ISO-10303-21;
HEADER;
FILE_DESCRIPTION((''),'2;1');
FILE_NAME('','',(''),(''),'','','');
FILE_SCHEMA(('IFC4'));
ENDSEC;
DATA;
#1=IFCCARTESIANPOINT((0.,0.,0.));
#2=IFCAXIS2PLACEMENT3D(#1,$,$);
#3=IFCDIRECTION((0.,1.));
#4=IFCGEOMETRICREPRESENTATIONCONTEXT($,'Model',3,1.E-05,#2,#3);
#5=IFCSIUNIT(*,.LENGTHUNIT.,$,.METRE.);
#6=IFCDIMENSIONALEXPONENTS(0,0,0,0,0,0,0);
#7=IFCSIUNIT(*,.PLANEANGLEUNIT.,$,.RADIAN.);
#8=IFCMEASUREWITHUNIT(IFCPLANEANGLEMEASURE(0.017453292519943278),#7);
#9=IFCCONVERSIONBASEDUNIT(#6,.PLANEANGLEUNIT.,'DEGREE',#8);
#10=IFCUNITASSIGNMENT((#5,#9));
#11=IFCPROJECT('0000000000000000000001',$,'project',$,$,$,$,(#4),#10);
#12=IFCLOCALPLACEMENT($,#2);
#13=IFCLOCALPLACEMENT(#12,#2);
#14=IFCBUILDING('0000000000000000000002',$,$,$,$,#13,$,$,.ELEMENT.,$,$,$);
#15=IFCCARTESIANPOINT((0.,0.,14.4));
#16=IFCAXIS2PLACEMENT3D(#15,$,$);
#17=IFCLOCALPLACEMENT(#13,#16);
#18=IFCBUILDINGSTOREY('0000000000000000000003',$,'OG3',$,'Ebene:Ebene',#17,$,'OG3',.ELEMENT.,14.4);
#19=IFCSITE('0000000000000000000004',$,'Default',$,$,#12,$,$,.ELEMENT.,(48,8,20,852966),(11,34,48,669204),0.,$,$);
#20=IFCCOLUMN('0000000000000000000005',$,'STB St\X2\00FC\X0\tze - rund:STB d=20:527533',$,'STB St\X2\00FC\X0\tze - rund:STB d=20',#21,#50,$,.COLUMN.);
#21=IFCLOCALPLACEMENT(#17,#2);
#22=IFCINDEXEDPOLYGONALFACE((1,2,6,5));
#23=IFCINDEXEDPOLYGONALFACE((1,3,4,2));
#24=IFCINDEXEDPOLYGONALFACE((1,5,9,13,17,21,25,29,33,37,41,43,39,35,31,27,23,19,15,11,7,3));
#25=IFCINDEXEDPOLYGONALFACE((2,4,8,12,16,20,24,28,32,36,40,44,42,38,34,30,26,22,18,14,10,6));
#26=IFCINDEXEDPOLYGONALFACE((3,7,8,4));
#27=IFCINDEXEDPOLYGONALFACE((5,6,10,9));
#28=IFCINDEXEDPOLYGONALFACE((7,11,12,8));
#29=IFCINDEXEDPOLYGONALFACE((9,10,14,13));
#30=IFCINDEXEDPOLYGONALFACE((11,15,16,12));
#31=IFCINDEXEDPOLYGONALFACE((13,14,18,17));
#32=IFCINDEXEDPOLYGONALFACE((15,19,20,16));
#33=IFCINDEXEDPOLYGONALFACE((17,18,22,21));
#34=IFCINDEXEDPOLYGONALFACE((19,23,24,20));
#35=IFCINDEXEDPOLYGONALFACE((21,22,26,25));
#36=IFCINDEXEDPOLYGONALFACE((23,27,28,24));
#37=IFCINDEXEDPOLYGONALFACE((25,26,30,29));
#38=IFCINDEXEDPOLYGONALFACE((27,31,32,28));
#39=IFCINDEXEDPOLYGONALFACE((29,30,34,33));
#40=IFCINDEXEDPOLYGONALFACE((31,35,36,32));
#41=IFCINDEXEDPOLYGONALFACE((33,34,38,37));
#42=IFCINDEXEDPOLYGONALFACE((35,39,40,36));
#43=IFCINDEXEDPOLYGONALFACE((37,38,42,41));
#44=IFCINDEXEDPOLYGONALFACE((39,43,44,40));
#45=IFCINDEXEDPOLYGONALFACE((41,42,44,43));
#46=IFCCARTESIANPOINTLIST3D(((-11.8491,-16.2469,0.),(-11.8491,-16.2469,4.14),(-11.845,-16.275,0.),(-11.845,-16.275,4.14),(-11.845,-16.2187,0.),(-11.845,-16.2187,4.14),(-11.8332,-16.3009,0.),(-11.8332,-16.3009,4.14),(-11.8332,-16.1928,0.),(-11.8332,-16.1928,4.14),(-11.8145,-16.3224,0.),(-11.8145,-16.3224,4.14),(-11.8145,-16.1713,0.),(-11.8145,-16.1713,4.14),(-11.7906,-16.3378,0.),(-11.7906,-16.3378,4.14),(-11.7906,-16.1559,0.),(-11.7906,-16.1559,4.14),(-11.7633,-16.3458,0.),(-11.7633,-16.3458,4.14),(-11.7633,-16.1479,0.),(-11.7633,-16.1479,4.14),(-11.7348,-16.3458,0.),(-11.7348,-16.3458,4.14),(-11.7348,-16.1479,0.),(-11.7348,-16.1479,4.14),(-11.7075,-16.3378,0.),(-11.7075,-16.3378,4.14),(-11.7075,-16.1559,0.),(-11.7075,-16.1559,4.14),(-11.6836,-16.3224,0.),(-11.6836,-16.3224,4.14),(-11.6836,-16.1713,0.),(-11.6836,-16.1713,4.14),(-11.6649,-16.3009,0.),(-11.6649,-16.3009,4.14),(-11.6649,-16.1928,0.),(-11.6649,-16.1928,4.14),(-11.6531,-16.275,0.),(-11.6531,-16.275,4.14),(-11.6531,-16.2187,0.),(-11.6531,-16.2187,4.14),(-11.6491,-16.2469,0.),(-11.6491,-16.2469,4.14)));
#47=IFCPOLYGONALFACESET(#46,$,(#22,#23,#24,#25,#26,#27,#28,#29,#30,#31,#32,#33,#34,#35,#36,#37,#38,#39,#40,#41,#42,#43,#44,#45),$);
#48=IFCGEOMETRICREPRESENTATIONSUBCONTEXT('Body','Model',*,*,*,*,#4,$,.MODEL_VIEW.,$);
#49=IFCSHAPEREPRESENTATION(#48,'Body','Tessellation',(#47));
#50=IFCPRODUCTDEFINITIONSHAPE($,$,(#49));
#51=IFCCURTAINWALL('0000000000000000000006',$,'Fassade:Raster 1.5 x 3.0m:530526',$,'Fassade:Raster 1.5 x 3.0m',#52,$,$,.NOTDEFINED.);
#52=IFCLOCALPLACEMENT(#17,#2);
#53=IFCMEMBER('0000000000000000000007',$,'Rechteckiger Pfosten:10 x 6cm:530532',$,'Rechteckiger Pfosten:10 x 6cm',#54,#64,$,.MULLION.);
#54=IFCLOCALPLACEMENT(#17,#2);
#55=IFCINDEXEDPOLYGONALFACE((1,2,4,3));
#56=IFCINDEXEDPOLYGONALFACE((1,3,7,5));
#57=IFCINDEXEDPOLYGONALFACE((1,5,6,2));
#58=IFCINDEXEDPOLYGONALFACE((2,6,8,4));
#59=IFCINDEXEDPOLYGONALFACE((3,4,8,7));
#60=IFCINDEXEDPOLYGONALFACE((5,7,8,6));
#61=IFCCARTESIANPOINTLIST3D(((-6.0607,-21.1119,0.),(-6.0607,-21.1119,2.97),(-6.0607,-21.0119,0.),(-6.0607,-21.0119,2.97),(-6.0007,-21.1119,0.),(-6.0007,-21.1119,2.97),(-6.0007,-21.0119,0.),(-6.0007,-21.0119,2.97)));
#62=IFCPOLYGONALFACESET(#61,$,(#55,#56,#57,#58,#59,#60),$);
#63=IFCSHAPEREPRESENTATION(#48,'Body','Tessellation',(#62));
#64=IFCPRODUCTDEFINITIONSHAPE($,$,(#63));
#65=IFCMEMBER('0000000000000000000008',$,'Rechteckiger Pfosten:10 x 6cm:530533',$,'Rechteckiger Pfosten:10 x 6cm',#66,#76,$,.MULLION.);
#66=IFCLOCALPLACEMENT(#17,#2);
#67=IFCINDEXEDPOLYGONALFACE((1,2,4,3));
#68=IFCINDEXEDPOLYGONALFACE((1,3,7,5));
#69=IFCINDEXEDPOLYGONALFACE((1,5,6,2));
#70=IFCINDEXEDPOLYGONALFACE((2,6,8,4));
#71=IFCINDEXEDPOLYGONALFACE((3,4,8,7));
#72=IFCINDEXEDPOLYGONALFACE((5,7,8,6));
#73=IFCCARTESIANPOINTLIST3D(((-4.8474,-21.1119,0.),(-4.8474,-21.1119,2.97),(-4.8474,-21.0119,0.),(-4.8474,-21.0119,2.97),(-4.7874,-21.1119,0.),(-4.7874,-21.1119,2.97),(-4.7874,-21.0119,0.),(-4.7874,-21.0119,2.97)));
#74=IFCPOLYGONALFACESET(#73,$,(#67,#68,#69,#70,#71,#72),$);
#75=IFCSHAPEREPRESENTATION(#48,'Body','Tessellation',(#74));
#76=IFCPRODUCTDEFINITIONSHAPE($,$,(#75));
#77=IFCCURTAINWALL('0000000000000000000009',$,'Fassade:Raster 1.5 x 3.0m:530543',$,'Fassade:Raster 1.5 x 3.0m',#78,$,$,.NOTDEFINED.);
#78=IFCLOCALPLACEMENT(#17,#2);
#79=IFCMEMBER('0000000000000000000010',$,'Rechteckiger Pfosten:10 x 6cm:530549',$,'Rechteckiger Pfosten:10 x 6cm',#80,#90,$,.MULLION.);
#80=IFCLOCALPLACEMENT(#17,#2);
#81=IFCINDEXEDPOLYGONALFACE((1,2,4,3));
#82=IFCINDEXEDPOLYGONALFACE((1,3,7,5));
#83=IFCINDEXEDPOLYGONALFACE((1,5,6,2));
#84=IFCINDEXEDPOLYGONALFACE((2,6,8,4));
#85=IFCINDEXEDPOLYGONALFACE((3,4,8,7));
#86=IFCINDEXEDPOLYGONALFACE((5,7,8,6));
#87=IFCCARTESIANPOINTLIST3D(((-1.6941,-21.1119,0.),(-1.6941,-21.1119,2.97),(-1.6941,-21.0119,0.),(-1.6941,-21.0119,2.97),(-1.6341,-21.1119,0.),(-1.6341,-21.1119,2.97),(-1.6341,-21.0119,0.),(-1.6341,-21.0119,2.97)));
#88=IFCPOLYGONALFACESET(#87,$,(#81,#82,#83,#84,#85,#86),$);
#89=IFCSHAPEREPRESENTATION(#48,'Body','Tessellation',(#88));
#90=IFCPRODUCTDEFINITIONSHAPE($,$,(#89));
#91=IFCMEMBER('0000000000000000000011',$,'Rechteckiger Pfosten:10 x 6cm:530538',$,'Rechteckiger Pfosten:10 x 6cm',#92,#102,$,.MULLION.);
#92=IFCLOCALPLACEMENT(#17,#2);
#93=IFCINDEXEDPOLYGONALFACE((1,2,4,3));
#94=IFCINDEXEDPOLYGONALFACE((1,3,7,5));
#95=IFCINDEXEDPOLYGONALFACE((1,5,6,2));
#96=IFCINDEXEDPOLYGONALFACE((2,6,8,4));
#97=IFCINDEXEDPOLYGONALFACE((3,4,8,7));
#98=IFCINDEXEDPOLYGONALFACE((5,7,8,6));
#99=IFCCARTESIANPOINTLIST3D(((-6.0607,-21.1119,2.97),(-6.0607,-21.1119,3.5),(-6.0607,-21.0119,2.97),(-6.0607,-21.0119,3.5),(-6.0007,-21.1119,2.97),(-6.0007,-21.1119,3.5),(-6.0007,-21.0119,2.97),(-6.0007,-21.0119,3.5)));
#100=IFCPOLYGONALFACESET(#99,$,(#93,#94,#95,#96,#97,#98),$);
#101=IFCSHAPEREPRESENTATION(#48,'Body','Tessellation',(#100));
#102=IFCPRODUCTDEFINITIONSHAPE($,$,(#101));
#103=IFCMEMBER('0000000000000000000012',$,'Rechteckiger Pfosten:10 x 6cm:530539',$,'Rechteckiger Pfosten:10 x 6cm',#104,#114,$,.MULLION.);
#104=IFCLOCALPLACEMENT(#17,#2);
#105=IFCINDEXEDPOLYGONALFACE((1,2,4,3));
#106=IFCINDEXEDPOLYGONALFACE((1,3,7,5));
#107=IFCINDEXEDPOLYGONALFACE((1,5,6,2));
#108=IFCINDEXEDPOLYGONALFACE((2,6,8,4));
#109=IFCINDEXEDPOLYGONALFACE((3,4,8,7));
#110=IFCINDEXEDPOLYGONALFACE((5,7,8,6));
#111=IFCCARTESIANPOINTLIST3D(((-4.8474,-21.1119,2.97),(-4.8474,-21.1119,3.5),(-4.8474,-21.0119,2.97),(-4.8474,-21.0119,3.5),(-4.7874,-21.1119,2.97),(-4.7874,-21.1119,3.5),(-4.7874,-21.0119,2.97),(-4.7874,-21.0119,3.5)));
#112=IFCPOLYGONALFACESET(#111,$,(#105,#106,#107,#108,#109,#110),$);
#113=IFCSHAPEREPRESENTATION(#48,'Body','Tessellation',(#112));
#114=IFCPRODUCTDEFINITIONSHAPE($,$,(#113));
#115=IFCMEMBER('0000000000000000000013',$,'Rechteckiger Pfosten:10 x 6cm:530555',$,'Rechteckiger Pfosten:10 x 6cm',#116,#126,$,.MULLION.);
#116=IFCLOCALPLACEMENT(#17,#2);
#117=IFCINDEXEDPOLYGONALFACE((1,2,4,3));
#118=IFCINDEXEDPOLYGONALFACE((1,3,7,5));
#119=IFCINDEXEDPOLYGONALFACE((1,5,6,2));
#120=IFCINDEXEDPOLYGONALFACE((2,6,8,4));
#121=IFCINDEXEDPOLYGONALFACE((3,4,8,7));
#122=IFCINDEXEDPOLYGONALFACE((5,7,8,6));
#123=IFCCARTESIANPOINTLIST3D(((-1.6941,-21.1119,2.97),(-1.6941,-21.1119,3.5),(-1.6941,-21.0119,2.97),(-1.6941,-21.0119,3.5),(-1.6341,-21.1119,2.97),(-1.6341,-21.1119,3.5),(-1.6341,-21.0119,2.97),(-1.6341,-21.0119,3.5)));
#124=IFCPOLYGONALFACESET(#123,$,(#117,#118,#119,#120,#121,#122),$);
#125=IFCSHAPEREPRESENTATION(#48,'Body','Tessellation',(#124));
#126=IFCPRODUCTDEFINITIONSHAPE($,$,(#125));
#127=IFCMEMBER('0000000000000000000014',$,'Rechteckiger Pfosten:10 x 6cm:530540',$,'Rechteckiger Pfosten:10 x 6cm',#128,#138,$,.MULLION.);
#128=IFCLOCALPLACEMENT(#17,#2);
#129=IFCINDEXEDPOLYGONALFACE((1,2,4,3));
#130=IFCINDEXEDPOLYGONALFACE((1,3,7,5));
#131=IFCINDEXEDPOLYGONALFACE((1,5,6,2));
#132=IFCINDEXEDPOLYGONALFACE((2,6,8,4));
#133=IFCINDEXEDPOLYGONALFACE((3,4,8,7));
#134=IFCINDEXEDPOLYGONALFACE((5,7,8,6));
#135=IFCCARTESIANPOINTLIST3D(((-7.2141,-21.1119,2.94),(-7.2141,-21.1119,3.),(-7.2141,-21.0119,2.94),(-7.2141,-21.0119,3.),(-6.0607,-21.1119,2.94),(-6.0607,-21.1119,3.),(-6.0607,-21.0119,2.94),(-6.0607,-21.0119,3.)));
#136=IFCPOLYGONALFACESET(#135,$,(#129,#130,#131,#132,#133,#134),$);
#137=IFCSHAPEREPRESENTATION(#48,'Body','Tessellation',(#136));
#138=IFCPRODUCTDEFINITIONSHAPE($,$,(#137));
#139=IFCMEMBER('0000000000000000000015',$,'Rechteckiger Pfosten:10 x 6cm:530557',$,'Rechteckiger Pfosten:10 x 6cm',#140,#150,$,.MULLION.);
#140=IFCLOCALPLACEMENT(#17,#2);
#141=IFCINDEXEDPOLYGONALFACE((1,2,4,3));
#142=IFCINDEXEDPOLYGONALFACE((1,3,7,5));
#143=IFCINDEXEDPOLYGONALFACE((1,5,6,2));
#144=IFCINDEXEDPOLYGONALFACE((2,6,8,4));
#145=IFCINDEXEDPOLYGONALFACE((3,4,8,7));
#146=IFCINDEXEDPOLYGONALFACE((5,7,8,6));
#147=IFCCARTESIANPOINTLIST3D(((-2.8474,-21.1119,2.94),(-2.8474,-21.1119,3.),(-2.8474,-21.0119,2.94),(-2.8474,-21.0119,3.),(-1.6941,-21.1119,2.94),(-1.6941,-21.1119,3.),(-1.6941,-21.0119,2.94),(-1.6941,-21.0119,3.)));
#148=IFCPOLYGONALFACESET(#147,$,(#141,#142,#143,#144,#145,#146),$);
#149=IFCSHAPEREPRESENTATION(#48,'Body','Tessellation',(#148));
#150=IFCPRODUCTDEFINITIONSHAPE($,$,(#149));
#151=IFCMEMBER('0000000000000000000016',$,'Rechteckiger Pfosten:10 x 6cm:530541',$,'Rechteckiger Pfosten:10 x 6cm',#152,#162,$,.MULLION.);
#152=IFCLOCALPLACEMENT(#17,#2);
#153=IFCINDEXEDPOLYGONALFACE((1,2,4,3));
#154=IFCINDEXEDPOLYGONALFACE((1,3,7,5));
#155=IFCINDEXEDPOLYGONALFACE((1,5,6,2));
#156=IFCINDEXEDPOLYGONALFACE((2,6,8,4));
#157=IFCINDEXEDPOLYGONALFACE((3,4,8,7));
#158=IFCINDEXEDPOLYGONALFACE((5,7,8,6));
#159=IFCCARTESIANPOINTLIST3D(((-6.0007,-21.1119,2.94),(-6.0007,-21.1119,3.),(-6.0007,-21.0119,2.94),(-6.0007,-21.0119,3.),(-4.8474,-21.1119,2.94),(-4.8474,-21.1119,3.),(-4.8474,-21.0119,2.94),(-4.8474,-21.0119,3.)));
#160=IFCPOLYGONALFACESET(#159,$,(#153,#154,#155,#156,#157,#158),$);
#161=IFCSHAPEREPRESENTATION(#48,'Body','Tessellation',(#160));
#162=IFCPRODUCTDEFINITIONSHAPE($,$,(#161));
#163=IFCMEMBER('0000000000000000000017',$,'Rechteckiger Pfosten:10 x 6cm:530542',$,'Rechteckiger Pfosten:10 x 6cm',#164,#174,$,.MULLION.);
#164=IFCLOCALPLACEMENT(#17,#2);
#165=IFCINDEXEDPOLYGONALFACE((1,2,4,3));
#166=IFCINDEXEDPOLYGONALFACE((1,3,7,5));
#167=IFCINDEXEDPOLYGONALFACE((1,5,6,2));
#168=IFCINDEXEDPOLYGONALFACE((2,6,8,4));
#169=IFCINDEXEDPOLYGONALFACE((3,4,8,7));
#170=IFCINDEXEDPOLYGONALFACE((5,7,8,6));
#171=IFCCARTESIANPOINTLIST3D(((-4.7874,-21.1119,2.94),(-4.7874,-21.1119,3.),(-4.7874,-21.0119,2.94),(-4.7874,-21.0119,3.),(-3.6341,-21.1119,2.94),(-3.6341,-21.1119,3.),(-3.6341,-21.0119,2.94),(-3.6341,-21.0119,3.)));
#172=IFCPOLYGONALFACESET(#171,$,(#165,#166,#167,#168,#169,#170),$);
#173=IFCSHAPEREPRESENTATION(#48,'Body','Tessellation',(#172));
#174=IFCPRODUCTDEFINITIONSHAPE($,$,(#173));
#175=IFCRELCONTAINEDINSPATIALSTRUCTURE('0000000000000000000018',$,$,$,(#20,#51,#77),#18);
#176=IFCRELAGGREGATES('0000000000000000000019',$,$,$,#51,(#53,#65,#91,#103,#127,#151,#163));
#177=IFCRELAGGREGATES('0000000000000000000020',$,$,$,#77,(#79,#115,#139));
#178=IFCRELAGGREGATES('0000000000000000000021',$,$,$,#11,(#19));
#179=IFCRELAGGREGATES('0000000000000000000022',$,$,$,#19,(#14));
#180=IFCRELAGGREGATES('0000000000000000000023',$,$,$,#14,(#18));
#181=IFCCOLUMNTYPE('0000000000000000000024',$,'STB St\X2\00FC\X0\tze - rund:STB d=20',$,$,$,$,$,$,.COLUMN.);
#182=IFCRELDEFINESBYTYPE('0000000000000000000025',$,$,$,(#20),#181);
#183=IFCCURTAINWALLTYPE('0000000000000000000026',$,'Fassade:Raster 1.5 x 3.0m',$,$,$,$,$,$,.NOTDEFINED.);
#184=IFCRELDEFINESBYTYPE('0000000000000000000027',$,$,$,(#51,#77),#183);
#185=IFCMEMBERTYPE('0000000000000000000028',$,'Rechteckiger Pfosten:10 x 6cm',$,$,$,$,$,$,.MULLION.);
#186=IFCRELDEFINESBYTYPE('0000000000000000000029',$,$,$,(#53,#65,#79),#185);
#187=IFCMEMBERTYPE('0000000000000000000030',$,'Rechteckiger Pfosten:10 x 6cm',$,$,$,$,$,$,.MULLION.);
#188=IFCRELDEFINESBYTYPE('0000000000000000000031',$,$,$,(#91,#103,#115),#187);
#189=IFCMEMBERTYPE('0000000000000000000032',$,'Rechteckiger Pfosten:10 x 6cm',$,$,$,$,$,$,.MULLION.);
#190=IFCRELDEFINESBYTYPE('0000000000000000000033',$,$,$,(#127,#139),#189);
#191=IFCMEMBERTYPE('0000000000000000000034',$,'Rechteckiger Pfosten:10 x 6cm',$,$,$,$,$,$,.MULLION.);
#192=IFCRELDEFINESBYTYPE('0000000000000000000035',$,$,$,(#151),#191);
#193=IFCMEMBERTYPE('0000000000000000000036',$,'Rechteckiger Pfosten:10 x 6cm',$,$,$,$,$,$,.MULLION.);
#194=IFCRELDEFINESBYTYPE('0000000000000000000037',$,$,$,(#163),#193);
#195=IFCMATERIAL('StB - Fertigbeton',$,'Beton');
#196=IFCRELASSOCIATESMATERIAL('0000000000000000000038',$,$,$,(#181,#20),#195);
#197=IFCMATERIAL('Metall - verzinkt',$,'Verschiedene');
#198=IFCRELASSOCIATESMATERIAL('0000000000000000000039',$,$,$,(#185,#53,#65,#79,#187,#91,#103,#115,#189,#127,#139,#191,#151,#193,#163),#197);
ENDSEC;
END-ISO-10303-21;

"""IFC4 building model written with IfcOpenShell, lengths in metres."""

from ifc_helpers import new_model, entity, si_unit, converted_unit, direction, frame, origin, place, context, subcontext, project, spatial, arc, indexed_curve, outline, extrude, source, transform, mapped, material, type_object, type_shapes, element, aggregate, save


model = new_model("IFC4")

# Units and contexts
model_context = context("Model", 3, precision=1e-05, world=origin(), true_north=direction((0.0, 1.0)))
body_context = subcontext(model_context, "Body", "Model", "MODEL_VIEW")
ifc_project = project(units=[si_unit("LENGTHUNIT", "METRE"), converted_unit("PLANEANGLEUNIT", "DEGREE", entity("IfcPlaneAngleMeasure", 0.017453292519943278), si_unit("PLANEANGLEUNIT", "RADIAN"), dimensions=[0, 0, 0, 0, 0, 0, 0])], contexts=[model_context])

# Site, building, storey
site_placement = place(None, origin())
site = spatial("IfcSite", under=ifc_project, at=site_placement, Name="Default", CompositionType="ELEMENT", RefLatitude=(48, 8, 20, 852966), RefLongitude=(11, 34, 48, 669204), RefElevation=0.0)
building_placement = place(site_placement, origin())
building = spatial("IfcBuilding", under=site, at=building_placement, CompositionType="ELEMENT")
storey_placement = place(building_placement, frame((0.0, 0.0, 14.4)))
storey = spatial("IfcBuildingStorey", under=building, at=storey_placement, Name="OG3", ObjectType="Ebene:Ebene", LongName="OG3", CompositionType="ELEMENT", Elevation=14.4)

# Column
ifc_material_1 = material(Name="StB - Fertigbeton", Category="Beton")
column_type = type_object("IfcColumnType", Name="STB Stütze - rund:STB d=20", PredefinedType="COLUMN", material=ifc_material_1)
shared_shape_1 = source(origin(), body_context, "Body", "SweptSolid", [
    extrude(outline(indexed_curve([(-0.1, 0.0), (0.0, -0.1), (0.1, 0.0), (0.0, 0.1)], segments=[arc(1, 2, 3), arc(3, 4, 1)], self_intersect=False)), frame((0.0, 0.0, 14.4)), (0.0, 0.0, 1.0), 4.14),
])
type_shapes(column_type, [shared_shape_1])
column_placement = place(storey_placement, frame((-11.7491, -16.2469, -14.4), z_axis=(0.0, 0.0, 1.0), x_axis=(-1.0, 0.0, 0.0)))
element("IfcColumn", 1, at=column_placement, inside=storey, type_object=column_type, material=ifc_material_1, Name="STB Stütze - rund:STB d=20:527533", ObjectType="STB Stütze - rund:STB d=20", PredefinedType="COLUMN", context=body_context, shape_type="MappedRepresentation", body=[
    mapped(shared_shape_1, transform((0.0, 0.0, 0.0), scale=1.0)),
])

# Curtain wall, members
curtain_wall_type = type_object("IfcCurtainWallType", Name="Fassade:Raster 1.5 x 3.0m", PredefinedType="NOTDEFINED")
curtain_wall_1_placement = place(storey_placement, frame((0.0, 0.0, -14.4)))
curtain_wall_1 = element("IfcCurtainWall", 2, at=curtain_wall_1_placement, inside=storey, type_object=curtain_wall_type, Name="Fassade:Raster 1.5 x 3.0m:530526", ObjectType="Fassade:Raster 1.5 x 3.0m", PredefinedType="NOTDEFINED")
ifc_material_2 = material(Name="Metall - verzinkt", Category="Verschiedene")
member_type_1 = type_object("IfcMemberType", Name="Rechteckiger Pfosten:10 x 6cm", PredefinedType="MULLION", material=ifc_material_2)
shared_shape_2 = source(origin(), body_context, "Body", "SweptSolid", [
    extrude(outline(indexed_curve([(-0.03, -0.05), (0.03, -0.05), (0.03, 0.05), (-0.03, 0.05), (-0.03, -0.05)], self_intersect=False)), frame((0.0, 0.0, -2.97), z_axis=(0.0, 0.0, 1.0), x_axis=(-1.0, 0.0, 0.0)), (0.0, 0.0, 1.0), 2.97),
])
type_shapes(member_type_1, [shared_shape_2])
member_1_placement = place(curtain_wall_1_placement, frame((-6.0307, -21.0619, 14.4), z_axis=(0.0, 0.0, -1.0), x_axis=(1.0, 0.0, 0.0)))
member_1 = element("IfcMember", 3, at=member_1_placement, type_object=member_type_1, material=ifc_material_2, Name="Rechteckiger Pfosten:10 x 6cm:530532", ObjectType="Rechteckiger Pfosten:10 x 6cm", PredefinedType="MULLION", context=body_context, shape_type="MappedRepresentation", body=[
    mapped(shared_shape_2, transform((0.0, 0.0, 0.0), scale=1.0)),
])
member_2_placement = place(curtain_wall_1_placement, frame((-4.8174, -21.0619, 14.4), z_axis=(0.0, 0.0, -1.0), x_axis=(1.0, 0.0, 0.0)))
member_2 = element("IfcMember", 4, at=member_2_placement, type_object=member_type_1, material=ifc_material_2, Name="Rechteckiger Pfosten:10 x 6cm:530533", ObjectType="Rechteckiger Pfosten:10 x 6cm", PredefinedType="MULLION", context=body_context, shape_type="MappedRepresentation", body=[
    mapped(shared_shape_2, transform((0.0, 0.0, 0.0), scale=1.0)),
])

# Curtain wall, member
curtain_wall_2_placement = place(storey_placement, frame((0.0, 0.0, -14.4)))
curtain_wall_2 = element("IfcCurtainWall", 5, at=curtain_wall_2_placement, inside=storey, type_object=curtain_wall_type, Name="Fassade:Raster 1.5 x 3.0m:530543", ObjectType="Fassade:Raster 1.5 x 3.0m", PredefinedType="NOTDEFINED")
member_3_placement = place(curtain_wall_2_placement, frame((-1.6641, -21.0619, 14.4), z_axis=(0.0, 0.0, -1.0), x_axis=(1.0, 0.0, 0.0)))
member_3 = element("IfcMember", 6, at=member_3_placement, type_object=member_type_1, material=ifc_material_2, Name="Rechteckiger Pfosten:10 x 6cm:530549", ObjectType="Rechteckiger Pfosten:10 x 6cm", PredefinedType="MULLION", context=body_context, shape_type="MappedRepresentation", body=[
    mapped(shared_shape_2, transform((0.0, 0.0, 0.0), scale=1.0)),
])

# Members
member_type_2 = type_object("IfcMemberType", Name="Rechteckiger Pfosten:10 x 6cm", PredefinedType="MULLION", material=ifc_material_2)
shared_shape_3 = source(origin(), body_context, "Body", "SweptSolid", [
    extrude(outline(indexed_curve([(-0.03, -0.05), (0.03, -0.05), (0.03, 0.05), (-0.03, 0.05), (-0.03, -0.05)], self_intersect=False)), frame((0.0, 0.0, -0.53), z_axis=(0.0, 0.0, 1.0), x_axis=(-1.0, 0.0, 0.0)), (0.0, 0.0, 1.0), 0.53),
])
type_shapes(member_type_2, [shared_shape_3])
member_4_placement = place(curtain_wall_1_placement, frame((-6.0307, -21.0619, 17.37), z_axis=(0.0, 0.0, -1.0), x_axis=(1.0, 0.0, 0.0)))
member_4 = element("IfcMember", 7, at=member_4_placement, type_object=member_type_2, material=ifc_material_2, Name="Rechteckiger Pfosten:10 x 6cm:530538", ObjectType="Rechteckiger Pfosten:10 x 6cm", PredefinedType="MULLION", context=body_context, shape_type="MappedRepresentation", body=[
    mapped(shared_shape_3, transform((0.0, 0.0, 0.0), scale=1.0)),
])
member_5_placement = place(curtain_wall_1_placement, frame((-4.8174, -21.0619, 17.37), z_axis=(0.0, 0.0, -1.0), x_axis=(1.0, 0.0, 0.0)))
member_5 = element("IfcMember", 8, at=member_5_placement, type_object=member_type_2, material=ifc_material_2, Name="Rechteckiger Pfosten:10 x 6cm:530539", ObjectType="Rechteckiger Pfosten:10 x 6cm", PredefinedType="MULLION", context=body_context, shape_type="MappedRepresentation", body=[
    mapped(shared_shape_3, transform((0.0, 0.0, 0.0), scale=1.0)),
])
member_6_placement = place(curtain_wall_2_placement, frame((-1.6641, -21.0619, 17.37), z_axis=(0.0, 0.0, -1.0), x_axis=(1.0, 0.0, 0.0)))
member_6 = element("IfcMember", 9, at=member_6_placement, type_object=member_type_2, material=ifc_material_2, Name="Rechteckiger Pfosten:10 x 6cm:530555", ObjectType="Rechteckiger Pfosten:10 x 6cm", PredefinedType="MULLION", context=body_context, shape_type="MappedRepresentation", body=[
    mapped(shared_shape_3, transform((0.0, 0.0, 0.0), scale=1.0)),
])
member_type_3 = type_object("IfcMemberType", Name="Rechteckiger Pfosten:10 x 6cm", PredefinedType="MULLION", material=ifc_material_2)
shared_shape_4 = source(origin(), body_context, "Body", "SweptSolid", [
    extrude(outline(indexed_curve([(-0.03, -0.05), (0.03, -0.05), (0.03, 0.05), (-0.03, 0.05), (-0.03, -0.05)], self_intersect=False)), frame((0.0, 0.0, -1.1533), z_axis=(0.0, 0.0, 1.0), x_axis=(-1.0, 0.0, 0.0)), (0.0, 0.0, 1.0), 1.1533),
])
type_shapes(member_type_3, [shared_shape_4])
member_7_placement = place(curtain_wall_1_placement, frame((-6.0607, -21.0619, 17.37), z_axis=(1.0, 0.0, 0.0), x_axis=(0.0, 0.0, 1.0)))
member_7 = element("IfcMember", 10, at=member_7_placement, type_object=member_type_3, material=ifc_material_2, Name="Rechteckiger Pfosten:10 x 6cm:530540", ObjectType="Rechteckiger Pfosten:10 x 6cm", PredefinedType="MULLION", context=body_context, shape_type="MappedRepresentation", body=[
    mapped(shared_shape_4, transform((0.0, 0.0, 0.0), scale=1.0)),
])
member_8_placement = place(curtain_wall_2_placement, frame((-1.6941, -21.0619, 17.37), z_axis=(1.0, 0.0, 0.0), x_axis=(0.0, 0.0, 1.0)))
member_8 = element("IfcMember", 11, at=member_8_placement, type_object=member_type_3, material=ifc_material_2, Name="Rechteckiger Pfosten:10 x 6cm:530557", ObjectType="Rechteckiger Pfosten:10 x 6cm", PredefinedType="MULLION", context=body_context, shape_type="MappedRepresentation", body=[
    mapped(shared_shape_4, transform((0.0, 0.0, 0.0), scale=1.0)),
])
member_type_4 = type_object("IfcMemberType", Name="Rechteckiger Pfosten:10 x 6cm", PredefinedType="MULLION", material=ifc_material_2)
shared_shape_5 = source(origin(), body_context, "Body", "SweptSolid", [
    extrude(outline(indexed_curve([(-0.03, -0.05), (0.03, -0.05), (0.03, 0.05), (-0.03, 0.05), (-0.03, -0.05)], self_intersect=False)), frame((0.0, 0.0, -1.1533), z_axis=(0.0, 0.0, 1.0), x_axis=(-1.0, 0.0, 0.0)), (0.0, 0.0, 1.0), 1.1533),
])
type_shapes(member_type_4, [shared_shape_5])
member_9_placement = place(curtain_wall_1_placement, frame((-4.8474, -21.0619, 17.37), z_axis=(1.0, 0.0, 0.0), x_axis=(0.0, 0.0, 1.0)))
member_9 = element("IfcMember", 12, at=member_9_placement, type_object=member_type_4, material=ifc_material_2, Name="Rechteckiger Pfosten:10 x 6cm:530541", ObjectType="Rechteckiger Pfosten:10 x 6cm", PredefinedType="MULLION", context=body_context, shape_type="MappedRepresentation", body=[
    mapped(shared_shape_5, transform((0.0, 0.0, 0.0), scale=1.0)),
])
member_type_5 = type_object("IfcMemberType", Name="Rechteckiger Pfosten:10 x 6cm", PredefinedType="MULLION", material=ifc_material_2)
shared_shape_6 = source(origin(), body_context, "Body", "SweptSolid", [
    extrude(outline(indexed_curve([(-0.03, -0.05), (0.03, -0.05), (0.03, 0.05), (-0.03, 0.05), (-0.03, -0.05)], self_intersect=False)), frame((0.0, 0.0, -1.1533), z_axis=(0.0, 0.0, 1.0), x_axis=(-1.0, 0.0, 0.0)), (0.0, 0.0, 1.0), 1.1533),
])
type_shapes(member_type_5, [shared_shape_6])
member_10_placement = place(curtain_wall_1_placement, frame((-3.6341, -21.0619, 17.37), z_axis=(1.0, 0.0, 0.0), x_axis=(0.0, 0.0, 1.0)))
member_10 = element("IfcMember", 13, at=member_10_placement, type_object=member_type_5, material=ifc_material_2, Name="Rechteckiger Pfosten:10 x 6cm:530542", ObjectType="Rechteckiger Pfosten:10 x 6cm", PredefinedType="MULLION", context=body_context, shape_type="MappedRepresentation", body=[
    mapped(shared_shape_6, transform((0.0, 0.0, 0.0), scale=1.0)),
])

aggregate(curtain_wall_1, [member_1, member_2, member_4, member_5, member_7, member_9, member_10])
aggregate(curtain_wall_2, [member_3, member_6, member_8])

save(model, "model.ifc")
